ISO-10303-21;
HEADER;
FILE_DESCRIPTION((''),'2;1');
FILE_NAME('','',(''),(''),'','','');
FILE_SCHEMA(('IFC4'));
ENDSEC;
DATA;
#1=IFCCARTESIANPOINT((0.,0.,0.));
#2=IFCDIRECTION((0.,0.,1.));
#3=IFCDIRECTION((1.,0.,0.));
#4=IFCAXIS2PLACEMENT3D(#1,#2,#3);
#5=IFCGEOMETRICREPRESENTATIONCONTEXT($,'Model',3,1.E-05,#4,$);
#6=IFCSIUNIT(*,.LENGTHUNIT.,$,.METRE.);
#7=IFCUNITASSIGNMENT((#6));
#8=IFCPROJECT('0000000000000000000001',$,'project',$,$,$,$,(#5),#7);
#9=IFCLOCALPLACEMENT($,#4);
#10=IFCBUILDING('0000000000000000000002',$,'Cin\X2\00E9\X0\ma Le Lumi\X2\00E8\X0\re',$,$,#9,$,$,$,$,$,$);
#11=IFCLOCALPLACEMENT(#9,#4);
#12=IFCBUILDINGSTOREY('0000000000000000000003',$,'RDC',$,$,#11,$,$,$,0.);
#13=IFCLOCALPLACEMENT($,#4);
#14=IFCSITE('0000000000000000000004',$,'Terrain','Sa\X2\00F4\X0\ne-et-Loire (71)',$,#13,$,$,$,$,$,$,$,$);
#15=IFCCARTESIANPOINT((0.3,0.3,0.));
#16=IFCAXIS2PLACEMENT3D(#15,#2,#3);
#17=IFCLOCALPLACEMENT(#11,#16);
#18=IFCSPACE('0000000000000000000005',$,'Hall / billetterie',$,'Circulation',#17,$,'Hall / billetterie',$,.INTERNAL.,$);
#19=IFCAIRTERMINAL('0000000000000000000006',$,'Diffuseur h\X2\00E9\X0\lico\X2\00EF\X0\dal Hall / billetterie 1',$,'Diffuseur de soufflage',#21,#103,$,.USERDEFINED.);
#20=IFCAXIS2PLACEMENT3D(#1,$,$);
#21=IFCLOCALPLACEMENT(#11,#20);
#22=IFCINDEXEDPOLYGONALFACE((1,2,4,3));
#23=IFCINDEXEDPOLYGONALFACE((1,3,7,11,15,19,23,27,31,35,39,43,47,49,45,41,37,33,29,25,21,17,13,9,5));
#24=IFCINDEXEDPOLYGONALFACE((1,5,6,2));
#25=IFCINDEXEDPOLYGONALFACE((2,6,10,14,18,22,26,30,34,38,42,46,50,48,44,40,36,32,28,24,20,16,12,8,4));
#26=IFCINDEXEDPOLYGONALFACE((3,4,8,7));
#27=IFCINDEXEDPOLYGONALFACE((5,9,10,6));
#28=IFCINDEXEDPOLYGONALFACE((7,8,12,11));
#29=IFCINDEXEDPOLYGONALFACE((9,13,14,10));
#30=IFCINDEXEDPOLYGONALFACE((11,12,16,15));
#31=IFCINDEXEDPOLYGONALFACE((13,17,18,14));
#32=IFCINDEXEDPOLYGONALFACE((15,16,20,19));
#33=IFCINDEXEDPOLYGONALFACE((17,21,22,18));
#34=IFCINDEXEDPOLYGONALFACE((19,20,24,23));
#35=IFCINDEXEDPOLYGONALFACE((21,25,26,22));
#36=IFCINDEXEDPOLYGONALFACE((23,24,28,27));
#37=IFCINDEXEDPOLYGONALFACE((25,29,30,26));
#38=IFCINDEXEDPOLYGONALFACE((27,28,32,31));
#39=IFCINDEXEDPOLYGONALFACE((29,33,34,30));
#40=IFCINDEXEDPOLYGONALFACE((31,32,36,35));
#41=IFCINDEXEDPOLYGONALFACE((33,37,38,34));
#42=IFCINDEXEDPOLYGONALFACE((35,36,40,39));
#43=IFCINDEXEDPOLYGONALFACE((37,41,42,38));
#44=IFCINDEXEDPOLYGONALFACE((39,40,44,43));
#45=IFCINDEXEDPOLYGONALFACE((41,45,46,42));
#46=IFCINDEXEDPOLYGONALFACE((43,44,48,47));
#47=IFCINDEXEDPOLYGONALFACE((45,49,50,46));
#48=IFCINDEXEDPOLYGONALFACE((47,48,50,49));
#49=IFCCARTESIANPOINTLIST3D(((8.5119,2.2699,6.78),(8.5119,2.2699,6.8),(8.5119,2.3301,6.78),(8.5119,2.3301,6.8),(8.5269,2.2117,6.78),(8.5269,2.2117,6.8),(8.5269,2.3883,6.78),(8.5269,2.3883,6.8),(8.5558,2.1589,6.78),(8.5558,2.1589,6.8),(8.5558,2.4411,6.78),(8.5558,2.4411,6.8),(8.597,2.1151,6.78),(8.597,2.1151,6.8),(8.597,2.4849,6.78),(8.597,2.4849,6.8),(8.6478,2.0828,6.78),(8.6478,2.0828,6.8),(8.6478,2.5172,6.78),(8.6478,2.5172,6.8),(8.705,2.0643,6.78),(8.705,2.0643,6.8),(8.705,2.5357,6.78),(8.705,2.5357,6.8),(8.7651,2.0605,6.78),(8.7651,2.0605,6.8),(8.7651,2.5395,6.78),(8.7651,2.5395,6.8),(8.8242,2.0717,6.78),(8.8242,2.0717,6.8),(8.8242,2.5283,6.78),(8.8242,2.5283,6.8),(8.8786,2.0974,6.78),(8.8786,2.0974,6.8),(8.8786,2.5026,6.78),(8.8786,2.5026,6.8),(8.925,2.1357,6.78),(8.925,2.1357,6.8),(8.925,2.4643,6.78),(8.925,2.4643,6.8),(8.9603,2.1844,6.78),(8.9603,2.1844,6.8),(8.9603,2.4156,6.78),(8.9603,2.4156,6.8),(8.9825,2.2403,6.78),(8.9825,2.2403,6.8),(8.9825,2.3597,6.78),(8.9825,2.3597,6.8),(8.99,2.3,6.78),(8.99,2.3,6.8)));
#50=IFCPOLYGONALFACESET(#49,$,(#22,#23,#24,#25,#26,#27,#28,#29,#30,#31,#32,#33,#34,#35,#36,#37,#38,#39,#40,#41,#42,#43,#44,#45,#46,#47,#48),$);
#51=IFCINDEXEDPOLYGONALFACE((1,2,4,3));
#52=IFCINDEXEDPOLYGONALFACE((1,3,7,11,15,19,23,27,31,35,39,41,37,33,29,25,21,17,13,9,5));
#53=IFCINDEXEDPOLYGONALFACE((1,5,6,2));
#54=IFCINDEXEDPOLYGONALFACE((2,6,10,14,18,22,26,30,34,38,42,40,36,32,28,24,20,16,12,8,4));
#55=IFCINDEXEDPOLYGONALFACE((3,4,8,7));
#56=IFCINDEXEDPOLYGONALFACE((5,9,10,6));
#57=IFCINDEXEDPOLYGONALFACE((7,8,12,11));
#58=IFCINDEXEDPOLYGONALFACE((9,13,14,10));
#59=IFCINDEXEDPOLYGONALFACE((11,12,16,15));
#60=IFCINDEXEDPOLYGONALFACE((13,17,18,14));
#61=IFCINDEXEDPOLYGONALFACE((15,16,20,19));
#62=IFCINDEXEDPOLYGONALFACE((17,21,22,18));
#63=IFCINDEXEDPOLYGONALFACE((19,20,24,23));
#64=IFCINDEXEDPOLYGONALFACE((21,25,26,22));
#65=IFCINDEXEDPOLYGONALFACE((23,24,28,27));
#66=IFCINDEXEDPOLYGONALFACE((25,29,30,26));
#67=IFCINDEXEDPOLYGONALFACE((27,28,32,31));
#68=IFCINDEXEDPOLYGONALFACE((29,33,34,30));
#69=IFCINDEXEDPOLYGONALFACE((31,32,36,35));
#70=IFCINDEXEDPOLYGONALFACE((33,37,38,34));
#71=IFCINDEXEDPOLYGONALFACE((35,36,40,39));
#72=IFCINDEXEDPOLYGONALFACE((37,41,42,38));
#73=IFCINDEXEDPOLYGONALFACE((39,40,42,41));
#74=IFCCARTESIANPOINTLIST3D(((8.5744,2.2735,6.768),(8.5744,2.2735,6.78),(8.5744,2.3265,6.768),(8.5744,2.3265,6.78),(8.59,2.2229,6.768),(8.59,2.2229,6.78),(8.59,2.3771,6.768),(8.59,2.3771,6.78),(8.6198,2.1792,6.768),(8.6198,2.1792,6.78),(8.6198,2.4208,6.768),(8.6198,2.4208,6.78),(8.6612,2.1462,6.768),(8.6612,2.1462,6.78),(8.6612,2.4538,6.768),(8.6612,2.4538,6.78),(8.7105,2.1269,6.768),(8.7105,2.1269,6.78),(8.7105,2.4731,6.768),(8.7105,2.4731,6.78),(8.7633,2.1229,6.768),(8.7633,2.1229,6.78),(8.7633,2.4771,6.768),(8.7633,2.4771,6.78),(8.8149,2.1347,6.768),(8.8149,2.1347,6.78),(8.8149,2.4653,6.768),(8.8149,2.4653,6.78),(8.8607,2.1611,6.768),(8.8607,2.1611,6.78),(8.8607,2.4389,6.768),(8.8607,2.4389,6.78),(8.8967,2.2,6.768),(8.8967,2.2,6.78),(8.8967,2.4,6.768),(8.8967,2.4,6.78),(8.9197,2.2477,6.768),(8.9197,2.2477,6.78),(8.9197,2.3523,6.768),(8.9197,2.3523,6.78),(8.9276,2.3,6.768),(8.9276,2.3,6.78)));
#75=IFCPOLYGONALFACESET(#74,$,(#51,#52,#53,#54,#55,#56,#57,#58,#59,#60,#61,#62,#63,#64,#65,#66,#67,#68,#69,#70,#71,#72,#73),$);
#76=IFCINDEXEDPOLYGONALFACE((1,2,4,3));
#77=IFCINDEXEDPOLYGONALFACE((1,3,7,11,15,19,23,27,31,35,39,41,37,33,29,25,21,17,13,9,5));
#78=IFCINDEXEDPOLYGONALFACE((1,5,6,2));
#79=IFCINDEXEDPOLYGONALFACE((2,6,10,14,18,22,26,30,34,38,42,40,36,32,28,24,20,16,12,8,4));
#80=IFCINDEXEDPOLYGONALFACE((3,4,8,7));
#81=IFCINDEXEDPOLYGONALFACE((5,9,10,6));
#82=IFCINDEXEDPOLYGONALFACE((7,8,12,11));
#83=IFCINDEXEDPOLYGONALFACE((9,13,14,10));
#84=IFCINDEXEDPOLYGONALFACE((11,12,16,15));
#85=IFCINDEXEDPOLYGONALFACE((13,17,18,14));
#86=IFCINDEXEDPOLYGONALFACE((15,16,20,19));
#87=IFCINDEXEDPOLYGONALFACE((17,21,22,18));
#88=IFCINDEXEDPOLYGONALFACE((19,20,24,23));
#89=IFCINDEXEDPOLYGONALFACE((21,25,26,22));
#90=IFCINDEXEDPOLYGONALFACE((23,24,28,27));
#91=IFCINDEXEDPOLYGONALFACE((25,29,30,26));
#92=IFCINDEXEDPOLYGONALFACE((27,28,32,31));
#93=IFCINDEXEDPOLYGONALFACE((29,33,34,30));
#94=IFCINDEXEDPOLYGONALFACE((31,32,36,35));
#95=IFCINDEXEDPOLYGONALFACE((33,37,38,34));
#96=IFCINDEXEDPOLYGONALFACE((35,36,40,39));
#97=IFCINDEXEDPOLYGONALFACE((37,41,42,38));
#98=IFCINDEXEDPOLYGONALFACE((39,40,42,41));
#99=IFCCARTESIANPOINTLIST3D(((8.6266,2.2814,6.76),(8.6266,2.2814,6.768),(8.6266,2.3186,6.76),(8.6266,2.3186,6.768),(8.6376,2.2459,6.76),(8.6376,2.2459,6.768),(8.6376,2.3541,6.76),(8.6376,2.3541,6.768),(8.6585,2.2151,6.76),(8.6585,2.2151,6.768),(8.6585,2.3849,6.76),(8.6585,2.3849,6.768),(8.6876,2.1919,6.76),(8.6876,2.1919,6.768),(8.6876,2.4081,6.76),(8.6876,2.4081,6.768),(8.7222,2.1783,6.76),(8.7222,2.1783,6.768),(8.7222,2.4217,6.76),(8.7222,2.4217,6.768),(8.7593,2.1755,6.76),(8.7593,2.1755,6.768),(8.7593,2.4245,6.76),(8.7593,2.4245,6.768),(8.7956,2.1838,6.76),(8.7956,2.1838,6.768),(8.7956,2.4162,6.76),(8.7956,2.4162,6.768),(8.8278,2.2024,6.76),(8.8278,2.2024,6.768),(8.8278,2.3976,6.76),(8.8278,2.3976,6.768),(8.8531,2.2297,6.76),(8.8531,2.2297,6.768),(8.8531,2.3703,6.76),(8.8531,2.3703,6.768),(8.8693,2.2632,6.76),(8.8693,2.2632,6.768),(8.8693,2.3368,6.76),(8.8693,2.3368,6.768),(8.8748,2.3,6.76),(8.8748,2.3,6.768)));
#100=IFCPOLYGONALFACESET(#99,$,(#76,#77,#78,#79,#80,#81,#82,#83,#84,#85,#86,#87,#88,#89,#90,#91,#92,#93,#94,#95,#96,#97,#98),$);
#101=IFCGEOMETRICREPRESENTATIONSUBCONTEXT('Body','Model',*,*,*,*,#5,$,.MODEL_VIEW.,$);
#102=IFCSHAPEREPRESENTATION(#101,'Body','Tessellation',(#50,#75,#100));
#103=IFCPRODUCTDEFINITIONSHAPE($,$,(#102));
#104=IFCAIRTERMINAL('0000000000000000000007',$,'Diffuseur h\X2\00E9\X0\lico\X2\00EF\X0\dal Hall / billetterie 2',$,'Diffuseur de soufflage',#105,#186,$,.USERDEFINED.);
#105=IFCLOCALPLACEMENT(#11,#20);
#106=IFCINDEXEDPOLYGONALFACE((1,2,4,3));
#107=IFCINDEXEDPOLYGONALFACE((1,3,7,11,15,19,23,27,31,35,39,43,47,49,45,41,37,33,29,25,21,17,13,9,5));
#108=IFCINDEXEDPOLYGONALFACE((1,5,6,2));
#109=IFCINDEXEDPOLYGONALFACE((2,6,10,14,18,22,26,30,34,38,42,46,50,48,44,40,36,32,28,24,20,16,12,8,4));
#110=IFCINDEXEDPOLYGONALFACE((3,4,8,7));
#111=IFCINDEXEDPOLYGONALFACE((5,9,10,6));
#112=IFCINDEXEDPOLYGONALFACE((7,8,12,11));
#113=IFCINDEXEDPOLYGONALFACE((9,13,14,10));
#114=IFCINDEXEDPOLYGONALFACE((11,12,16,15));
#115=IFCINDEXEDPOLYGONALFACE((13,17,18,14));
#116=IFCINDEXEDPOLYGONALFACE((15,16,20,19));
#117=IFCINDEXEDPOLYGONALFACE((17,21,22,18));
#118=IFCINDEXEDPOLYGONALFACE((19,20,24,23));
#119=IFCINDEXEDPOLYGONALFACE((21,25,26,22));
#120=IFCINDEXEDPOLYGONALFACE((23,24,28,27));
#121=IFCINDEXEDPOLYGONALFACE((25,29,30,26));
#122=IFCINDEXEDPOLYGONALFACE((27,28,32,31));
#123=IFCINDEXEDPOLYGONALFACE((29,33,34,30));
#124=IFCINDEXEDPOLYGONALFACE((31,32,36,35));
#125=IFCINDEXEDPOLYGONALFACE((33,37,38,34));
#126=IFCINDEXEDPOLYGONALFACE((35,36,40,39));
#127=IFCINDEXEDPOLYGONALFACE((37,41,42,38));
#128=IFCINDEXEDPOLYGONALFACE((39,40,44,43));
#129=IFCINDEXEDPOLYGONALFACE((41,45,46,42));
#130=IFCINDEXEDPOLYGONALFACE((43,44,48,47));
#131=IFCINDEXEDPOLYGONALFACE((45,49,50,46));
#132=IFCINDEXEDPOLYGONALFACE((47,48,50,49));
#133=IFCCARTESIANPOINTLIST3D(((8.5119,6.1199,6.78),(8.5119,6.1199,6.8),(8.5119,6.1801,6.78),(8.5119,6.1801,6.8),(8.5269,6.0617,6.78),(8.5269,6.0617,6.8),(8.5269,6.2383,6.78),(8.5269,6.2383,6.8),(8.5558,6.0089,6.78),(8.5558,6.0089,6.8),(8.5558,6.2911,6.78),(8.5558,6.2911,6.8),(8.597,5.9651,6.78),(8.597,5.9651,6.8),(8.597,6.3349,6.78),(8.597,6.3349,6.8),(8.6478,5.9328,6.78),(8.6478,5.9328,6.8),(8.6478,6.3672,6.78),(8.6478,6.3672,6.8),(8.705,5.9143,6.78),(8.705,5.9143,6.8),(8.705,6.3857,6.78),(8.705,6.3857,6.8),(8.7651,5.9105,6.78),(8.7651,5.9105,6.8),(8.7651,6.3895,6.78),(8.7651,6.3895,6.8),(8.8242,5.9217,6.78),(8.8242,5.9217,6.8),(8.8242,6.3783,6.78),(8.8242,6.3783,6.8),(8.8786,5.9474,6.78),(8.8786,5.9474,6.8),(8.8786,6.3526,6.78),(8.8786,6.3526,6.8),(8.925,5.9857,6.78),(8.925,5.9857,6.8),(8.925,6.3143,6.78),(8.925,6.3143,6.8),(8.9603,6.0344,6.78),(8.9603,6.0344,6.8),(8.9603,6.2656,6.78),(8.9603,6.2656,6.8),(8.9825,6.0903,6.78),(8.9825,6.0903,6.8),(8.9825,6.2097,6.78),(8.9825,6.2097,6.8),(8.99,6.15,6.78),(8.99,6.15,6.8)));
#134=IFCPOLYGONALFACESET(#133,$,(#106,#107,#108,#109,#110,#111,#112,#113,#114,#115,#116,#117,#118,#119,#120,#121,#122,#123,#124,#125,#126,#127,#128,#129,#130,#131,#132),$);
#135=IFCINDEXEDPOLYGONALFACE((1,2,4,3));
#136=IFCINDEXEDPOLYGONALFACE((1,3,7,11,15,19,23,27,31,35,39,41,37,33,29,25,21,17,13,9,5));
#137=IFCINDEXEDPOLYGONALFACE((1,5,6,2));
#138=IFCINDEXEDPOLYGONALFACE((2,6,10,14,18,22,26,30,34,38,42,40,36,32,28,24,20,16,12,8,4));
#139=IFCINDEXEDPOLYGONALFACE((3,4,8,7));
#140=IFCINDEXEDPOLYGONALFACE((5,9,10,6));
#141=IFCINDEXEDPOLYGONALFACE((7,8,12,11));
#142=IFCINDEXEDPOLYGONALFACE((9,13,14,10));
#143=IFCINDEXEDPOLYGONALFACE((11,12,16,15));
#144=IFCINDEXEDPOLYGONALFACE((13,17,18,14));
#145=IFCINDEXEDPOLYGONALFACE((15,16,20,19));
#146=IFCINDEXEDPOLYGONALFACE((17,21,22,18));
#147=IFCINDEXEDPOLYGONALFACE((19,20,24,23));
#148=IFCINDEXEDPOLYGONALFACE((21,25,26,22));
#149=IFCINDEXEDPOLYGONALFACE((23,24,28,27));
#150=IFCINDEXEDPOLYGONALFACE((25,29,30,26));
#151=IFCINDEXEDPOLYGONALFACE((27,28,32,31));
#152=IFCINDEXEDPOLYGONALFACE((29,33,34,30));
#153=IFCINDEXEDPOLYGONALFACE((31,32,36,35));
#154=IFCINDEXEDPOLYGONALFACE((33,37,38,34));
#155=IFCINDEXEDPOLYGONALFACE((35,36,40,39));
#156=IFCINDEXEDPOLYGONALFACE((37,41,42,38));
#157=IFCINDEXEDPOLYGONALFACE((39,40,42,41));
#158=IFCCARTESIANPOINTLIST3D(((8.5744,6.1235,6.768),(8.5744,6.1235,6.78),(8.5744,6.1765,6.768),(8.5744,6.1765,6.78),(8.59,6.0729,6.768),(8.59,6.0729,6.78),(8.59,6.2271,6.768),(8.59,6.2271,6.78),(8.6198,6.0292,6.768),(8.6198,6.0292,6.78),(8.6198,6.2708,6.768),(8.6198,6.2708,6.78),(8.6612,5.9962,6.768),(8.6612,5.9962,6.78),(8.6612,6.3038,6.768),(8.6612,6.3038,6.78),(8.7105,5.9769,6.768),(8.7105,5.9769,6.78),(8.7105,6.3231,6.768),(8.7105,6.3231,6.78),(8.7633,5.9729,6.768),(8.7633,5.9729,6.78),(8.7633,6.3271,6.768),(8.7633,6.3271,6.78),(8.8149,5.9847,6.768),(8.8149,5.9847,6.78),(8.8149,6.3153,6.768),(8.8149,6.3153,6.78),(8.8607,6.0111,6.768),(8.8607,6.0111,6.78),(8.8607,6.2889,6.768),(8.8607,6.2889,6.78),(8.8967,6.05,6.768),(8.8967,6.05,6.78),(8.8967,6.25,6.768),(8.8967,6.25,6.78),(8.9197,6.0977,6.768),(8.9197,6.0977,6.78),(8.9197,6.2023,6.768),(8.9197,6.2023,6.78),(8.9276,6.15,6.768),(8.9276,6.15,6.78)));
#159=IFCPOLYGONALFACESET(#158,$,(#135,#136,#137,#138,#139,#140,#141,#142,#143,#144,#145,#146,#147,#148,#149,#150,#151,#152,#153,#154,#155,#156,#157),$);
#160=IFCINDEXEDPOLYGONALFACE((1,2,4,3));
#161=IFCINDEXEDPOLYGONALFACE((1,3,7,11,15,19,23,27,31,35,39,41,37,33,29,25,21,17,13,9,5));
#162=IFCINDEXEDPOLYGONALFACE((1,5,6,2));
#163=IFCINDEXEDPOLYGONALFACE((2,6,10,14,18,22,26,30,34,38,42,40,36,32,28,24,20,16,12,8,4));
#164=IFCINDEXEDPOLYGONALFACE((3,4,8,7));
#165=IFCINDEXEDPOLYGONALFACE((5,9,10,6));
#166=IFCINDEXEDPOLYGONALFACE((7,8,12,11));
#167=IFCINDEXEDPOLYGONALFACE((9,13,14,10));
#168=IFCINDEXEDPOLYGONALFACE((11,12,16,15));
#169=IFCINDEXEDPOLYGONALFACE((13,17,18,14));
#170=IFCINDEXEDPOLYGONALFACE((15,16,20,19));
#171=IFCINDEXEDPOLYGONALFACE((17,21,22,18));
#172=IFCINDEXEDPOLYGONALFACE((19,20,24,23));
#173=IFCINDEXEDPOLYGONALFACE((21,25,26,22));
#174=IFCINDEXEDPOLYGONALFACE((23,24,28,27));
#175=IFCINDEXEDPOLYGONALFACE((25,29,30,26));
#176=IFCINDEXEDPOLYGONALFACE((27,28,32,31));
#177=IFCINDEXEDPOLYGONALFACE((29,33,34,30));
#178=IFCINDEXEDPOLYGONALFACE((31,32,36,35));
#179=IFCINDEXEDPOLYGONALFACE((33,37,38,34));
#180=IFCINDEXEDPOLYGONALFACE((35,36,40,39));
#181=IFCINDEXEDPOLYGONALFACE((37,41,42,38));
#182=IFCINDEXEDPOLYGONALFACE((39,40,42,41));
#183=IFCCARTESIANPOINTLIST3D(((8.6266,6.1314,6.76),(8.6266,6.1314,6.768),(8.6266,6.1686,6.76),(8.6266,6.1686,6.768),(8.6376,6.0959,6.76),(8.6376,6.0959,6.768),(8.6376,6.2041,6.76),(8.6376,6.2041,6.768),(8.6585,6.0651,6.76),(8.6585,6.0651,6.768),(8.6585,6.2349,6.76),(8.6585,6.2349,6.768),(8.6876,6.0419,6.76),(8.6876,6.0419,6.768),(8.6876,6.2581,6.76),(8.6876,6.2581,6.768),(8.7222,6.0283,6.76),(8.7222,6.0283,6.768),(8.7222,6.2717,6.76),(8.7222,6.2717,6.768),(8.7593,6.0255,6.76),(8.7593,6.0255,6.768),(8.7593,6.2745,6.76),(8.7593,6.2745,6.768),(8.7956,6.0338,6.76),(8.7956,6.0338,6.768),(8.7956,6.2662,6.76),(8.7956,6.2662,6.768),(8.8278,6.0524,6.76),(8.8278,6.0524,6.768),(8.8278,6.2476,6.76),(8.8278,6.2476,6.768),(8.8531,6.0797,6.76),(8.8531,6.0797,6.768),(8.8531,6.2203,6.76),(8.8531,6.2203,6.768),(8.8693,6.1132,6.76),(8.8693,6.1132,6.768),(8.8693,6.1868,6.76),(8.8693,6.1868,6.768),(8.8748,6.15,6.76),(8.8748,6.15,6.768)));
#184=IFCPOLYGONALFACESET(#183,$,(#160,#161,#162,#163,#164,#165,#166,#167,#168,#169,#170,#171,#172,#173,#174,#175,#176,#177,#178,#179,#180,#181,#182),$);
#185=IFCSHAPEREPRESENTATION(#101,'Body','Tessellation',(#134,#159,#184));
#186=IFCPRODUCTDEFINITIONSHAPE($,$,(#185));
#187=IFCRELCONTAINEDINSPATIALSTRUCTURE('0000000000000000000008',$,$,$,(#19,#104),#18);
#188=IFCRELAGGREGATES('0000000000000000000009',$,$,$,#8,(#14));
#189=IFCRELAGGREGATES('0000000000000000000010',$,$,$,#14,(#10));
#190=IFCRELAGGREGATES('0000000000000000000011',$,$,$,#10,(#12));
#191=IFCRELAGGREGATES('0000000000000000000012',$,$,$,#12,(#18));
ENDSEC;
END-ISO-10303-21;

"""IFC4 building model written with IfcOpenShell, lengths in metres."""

from ifc_helpers import new_model, si_unit, frame, origin_with_axes, place, context, subcontext, project, spatial, circle, extrude, element, save


model = new_model("IFC4")

# Units and contexts
model_context = context("Model", 3, precision=1e-05, world=origin_with_axes())
body_context = subcontext(model_context, "Body", "Model", "MODEL_VIEW")
ifc_project = project(units=[si_unit("LENGTHUNIT", "METRE")], contexts=[model_context])

# Site, building, storey
site_placement = place(None, origin_with_axes())
site = spatial("IfcSite", under=ifc_project, at=site_placement, Name="Terrain", Description="Saône-et-Loire (71)")
building_placement = place(None, origin_with_axes())
building = spatial("IfcBuilding", under=site, at=building_placement, Name="Cinéma Le Lumière")
storey_placement = place(building_placement, origin_with_axes())
storey = spatial("IfcBuildingStorey", under=building, at=storey_placement, Name="RDC", Elevation=0.0)

# Shared definitions
space_1_placement = place(storey_placement, frame((0.3, 0.3, 0.0), z_axis=(0.0, 0.0, 1.0), x_axis=(1.0, 0.0, 0.0)))
space_1 = spatial("IfcSpace", under=storey, at=space_1_placement, Name="Hall / billetterie", ObjectType="Circulation", LongName="Hall / billetterie", PredefinedType="INTERNAL")

# Air terminals
for number, where, z_axis, x_axis, name in (
    (1, (8.45, 2.0, 6.76), (0.0, 0.0, 1.0), (1.0, 0.0, 0.0), "Diffuseur hélicoïdal Hall / billetterie 1"),
    (2, (8.45, 5.85, 6.76), (0.0, 0.0, 1.0), (1.0, 0.0, 0.0), "Diffuseur hélicoïdal Hall / billetterie 2"),
):
    element("IfcAirTerminal", number, at=place(space_1_placement, frame(where, z_axis=z_axis, x_axis=x_axis)), inside=space_1, Name=name, ObjectType="Diffuseur de soufflage", PredefinedType="USERDEFINED", context=body_context, shape_type="SweptSolid", body=[
        extrude(circle(Radius=0.24), frame((0.0, 0.0, 0.02), z_axis=(0.0, 0.0, 1.0), x_axis=(1.0, 0.0, 0.0)), (0.0, 0.0, 1.0), 0.02),
        extrude(circle(Radius=0.1776), frame((0.0, 0.0, 0.008), z_axis=(0.0, 0.0, 1.0), x_axis=(1.0, 0.0, 0.0)), (0.0, 0.0, 1.0), 0.012),
        extrude(circle(Radius=0.1248), origin_with_axes(), (0.0, 0.0, 1.0), 0.008),
    ])

save(model, "model.ifc")
